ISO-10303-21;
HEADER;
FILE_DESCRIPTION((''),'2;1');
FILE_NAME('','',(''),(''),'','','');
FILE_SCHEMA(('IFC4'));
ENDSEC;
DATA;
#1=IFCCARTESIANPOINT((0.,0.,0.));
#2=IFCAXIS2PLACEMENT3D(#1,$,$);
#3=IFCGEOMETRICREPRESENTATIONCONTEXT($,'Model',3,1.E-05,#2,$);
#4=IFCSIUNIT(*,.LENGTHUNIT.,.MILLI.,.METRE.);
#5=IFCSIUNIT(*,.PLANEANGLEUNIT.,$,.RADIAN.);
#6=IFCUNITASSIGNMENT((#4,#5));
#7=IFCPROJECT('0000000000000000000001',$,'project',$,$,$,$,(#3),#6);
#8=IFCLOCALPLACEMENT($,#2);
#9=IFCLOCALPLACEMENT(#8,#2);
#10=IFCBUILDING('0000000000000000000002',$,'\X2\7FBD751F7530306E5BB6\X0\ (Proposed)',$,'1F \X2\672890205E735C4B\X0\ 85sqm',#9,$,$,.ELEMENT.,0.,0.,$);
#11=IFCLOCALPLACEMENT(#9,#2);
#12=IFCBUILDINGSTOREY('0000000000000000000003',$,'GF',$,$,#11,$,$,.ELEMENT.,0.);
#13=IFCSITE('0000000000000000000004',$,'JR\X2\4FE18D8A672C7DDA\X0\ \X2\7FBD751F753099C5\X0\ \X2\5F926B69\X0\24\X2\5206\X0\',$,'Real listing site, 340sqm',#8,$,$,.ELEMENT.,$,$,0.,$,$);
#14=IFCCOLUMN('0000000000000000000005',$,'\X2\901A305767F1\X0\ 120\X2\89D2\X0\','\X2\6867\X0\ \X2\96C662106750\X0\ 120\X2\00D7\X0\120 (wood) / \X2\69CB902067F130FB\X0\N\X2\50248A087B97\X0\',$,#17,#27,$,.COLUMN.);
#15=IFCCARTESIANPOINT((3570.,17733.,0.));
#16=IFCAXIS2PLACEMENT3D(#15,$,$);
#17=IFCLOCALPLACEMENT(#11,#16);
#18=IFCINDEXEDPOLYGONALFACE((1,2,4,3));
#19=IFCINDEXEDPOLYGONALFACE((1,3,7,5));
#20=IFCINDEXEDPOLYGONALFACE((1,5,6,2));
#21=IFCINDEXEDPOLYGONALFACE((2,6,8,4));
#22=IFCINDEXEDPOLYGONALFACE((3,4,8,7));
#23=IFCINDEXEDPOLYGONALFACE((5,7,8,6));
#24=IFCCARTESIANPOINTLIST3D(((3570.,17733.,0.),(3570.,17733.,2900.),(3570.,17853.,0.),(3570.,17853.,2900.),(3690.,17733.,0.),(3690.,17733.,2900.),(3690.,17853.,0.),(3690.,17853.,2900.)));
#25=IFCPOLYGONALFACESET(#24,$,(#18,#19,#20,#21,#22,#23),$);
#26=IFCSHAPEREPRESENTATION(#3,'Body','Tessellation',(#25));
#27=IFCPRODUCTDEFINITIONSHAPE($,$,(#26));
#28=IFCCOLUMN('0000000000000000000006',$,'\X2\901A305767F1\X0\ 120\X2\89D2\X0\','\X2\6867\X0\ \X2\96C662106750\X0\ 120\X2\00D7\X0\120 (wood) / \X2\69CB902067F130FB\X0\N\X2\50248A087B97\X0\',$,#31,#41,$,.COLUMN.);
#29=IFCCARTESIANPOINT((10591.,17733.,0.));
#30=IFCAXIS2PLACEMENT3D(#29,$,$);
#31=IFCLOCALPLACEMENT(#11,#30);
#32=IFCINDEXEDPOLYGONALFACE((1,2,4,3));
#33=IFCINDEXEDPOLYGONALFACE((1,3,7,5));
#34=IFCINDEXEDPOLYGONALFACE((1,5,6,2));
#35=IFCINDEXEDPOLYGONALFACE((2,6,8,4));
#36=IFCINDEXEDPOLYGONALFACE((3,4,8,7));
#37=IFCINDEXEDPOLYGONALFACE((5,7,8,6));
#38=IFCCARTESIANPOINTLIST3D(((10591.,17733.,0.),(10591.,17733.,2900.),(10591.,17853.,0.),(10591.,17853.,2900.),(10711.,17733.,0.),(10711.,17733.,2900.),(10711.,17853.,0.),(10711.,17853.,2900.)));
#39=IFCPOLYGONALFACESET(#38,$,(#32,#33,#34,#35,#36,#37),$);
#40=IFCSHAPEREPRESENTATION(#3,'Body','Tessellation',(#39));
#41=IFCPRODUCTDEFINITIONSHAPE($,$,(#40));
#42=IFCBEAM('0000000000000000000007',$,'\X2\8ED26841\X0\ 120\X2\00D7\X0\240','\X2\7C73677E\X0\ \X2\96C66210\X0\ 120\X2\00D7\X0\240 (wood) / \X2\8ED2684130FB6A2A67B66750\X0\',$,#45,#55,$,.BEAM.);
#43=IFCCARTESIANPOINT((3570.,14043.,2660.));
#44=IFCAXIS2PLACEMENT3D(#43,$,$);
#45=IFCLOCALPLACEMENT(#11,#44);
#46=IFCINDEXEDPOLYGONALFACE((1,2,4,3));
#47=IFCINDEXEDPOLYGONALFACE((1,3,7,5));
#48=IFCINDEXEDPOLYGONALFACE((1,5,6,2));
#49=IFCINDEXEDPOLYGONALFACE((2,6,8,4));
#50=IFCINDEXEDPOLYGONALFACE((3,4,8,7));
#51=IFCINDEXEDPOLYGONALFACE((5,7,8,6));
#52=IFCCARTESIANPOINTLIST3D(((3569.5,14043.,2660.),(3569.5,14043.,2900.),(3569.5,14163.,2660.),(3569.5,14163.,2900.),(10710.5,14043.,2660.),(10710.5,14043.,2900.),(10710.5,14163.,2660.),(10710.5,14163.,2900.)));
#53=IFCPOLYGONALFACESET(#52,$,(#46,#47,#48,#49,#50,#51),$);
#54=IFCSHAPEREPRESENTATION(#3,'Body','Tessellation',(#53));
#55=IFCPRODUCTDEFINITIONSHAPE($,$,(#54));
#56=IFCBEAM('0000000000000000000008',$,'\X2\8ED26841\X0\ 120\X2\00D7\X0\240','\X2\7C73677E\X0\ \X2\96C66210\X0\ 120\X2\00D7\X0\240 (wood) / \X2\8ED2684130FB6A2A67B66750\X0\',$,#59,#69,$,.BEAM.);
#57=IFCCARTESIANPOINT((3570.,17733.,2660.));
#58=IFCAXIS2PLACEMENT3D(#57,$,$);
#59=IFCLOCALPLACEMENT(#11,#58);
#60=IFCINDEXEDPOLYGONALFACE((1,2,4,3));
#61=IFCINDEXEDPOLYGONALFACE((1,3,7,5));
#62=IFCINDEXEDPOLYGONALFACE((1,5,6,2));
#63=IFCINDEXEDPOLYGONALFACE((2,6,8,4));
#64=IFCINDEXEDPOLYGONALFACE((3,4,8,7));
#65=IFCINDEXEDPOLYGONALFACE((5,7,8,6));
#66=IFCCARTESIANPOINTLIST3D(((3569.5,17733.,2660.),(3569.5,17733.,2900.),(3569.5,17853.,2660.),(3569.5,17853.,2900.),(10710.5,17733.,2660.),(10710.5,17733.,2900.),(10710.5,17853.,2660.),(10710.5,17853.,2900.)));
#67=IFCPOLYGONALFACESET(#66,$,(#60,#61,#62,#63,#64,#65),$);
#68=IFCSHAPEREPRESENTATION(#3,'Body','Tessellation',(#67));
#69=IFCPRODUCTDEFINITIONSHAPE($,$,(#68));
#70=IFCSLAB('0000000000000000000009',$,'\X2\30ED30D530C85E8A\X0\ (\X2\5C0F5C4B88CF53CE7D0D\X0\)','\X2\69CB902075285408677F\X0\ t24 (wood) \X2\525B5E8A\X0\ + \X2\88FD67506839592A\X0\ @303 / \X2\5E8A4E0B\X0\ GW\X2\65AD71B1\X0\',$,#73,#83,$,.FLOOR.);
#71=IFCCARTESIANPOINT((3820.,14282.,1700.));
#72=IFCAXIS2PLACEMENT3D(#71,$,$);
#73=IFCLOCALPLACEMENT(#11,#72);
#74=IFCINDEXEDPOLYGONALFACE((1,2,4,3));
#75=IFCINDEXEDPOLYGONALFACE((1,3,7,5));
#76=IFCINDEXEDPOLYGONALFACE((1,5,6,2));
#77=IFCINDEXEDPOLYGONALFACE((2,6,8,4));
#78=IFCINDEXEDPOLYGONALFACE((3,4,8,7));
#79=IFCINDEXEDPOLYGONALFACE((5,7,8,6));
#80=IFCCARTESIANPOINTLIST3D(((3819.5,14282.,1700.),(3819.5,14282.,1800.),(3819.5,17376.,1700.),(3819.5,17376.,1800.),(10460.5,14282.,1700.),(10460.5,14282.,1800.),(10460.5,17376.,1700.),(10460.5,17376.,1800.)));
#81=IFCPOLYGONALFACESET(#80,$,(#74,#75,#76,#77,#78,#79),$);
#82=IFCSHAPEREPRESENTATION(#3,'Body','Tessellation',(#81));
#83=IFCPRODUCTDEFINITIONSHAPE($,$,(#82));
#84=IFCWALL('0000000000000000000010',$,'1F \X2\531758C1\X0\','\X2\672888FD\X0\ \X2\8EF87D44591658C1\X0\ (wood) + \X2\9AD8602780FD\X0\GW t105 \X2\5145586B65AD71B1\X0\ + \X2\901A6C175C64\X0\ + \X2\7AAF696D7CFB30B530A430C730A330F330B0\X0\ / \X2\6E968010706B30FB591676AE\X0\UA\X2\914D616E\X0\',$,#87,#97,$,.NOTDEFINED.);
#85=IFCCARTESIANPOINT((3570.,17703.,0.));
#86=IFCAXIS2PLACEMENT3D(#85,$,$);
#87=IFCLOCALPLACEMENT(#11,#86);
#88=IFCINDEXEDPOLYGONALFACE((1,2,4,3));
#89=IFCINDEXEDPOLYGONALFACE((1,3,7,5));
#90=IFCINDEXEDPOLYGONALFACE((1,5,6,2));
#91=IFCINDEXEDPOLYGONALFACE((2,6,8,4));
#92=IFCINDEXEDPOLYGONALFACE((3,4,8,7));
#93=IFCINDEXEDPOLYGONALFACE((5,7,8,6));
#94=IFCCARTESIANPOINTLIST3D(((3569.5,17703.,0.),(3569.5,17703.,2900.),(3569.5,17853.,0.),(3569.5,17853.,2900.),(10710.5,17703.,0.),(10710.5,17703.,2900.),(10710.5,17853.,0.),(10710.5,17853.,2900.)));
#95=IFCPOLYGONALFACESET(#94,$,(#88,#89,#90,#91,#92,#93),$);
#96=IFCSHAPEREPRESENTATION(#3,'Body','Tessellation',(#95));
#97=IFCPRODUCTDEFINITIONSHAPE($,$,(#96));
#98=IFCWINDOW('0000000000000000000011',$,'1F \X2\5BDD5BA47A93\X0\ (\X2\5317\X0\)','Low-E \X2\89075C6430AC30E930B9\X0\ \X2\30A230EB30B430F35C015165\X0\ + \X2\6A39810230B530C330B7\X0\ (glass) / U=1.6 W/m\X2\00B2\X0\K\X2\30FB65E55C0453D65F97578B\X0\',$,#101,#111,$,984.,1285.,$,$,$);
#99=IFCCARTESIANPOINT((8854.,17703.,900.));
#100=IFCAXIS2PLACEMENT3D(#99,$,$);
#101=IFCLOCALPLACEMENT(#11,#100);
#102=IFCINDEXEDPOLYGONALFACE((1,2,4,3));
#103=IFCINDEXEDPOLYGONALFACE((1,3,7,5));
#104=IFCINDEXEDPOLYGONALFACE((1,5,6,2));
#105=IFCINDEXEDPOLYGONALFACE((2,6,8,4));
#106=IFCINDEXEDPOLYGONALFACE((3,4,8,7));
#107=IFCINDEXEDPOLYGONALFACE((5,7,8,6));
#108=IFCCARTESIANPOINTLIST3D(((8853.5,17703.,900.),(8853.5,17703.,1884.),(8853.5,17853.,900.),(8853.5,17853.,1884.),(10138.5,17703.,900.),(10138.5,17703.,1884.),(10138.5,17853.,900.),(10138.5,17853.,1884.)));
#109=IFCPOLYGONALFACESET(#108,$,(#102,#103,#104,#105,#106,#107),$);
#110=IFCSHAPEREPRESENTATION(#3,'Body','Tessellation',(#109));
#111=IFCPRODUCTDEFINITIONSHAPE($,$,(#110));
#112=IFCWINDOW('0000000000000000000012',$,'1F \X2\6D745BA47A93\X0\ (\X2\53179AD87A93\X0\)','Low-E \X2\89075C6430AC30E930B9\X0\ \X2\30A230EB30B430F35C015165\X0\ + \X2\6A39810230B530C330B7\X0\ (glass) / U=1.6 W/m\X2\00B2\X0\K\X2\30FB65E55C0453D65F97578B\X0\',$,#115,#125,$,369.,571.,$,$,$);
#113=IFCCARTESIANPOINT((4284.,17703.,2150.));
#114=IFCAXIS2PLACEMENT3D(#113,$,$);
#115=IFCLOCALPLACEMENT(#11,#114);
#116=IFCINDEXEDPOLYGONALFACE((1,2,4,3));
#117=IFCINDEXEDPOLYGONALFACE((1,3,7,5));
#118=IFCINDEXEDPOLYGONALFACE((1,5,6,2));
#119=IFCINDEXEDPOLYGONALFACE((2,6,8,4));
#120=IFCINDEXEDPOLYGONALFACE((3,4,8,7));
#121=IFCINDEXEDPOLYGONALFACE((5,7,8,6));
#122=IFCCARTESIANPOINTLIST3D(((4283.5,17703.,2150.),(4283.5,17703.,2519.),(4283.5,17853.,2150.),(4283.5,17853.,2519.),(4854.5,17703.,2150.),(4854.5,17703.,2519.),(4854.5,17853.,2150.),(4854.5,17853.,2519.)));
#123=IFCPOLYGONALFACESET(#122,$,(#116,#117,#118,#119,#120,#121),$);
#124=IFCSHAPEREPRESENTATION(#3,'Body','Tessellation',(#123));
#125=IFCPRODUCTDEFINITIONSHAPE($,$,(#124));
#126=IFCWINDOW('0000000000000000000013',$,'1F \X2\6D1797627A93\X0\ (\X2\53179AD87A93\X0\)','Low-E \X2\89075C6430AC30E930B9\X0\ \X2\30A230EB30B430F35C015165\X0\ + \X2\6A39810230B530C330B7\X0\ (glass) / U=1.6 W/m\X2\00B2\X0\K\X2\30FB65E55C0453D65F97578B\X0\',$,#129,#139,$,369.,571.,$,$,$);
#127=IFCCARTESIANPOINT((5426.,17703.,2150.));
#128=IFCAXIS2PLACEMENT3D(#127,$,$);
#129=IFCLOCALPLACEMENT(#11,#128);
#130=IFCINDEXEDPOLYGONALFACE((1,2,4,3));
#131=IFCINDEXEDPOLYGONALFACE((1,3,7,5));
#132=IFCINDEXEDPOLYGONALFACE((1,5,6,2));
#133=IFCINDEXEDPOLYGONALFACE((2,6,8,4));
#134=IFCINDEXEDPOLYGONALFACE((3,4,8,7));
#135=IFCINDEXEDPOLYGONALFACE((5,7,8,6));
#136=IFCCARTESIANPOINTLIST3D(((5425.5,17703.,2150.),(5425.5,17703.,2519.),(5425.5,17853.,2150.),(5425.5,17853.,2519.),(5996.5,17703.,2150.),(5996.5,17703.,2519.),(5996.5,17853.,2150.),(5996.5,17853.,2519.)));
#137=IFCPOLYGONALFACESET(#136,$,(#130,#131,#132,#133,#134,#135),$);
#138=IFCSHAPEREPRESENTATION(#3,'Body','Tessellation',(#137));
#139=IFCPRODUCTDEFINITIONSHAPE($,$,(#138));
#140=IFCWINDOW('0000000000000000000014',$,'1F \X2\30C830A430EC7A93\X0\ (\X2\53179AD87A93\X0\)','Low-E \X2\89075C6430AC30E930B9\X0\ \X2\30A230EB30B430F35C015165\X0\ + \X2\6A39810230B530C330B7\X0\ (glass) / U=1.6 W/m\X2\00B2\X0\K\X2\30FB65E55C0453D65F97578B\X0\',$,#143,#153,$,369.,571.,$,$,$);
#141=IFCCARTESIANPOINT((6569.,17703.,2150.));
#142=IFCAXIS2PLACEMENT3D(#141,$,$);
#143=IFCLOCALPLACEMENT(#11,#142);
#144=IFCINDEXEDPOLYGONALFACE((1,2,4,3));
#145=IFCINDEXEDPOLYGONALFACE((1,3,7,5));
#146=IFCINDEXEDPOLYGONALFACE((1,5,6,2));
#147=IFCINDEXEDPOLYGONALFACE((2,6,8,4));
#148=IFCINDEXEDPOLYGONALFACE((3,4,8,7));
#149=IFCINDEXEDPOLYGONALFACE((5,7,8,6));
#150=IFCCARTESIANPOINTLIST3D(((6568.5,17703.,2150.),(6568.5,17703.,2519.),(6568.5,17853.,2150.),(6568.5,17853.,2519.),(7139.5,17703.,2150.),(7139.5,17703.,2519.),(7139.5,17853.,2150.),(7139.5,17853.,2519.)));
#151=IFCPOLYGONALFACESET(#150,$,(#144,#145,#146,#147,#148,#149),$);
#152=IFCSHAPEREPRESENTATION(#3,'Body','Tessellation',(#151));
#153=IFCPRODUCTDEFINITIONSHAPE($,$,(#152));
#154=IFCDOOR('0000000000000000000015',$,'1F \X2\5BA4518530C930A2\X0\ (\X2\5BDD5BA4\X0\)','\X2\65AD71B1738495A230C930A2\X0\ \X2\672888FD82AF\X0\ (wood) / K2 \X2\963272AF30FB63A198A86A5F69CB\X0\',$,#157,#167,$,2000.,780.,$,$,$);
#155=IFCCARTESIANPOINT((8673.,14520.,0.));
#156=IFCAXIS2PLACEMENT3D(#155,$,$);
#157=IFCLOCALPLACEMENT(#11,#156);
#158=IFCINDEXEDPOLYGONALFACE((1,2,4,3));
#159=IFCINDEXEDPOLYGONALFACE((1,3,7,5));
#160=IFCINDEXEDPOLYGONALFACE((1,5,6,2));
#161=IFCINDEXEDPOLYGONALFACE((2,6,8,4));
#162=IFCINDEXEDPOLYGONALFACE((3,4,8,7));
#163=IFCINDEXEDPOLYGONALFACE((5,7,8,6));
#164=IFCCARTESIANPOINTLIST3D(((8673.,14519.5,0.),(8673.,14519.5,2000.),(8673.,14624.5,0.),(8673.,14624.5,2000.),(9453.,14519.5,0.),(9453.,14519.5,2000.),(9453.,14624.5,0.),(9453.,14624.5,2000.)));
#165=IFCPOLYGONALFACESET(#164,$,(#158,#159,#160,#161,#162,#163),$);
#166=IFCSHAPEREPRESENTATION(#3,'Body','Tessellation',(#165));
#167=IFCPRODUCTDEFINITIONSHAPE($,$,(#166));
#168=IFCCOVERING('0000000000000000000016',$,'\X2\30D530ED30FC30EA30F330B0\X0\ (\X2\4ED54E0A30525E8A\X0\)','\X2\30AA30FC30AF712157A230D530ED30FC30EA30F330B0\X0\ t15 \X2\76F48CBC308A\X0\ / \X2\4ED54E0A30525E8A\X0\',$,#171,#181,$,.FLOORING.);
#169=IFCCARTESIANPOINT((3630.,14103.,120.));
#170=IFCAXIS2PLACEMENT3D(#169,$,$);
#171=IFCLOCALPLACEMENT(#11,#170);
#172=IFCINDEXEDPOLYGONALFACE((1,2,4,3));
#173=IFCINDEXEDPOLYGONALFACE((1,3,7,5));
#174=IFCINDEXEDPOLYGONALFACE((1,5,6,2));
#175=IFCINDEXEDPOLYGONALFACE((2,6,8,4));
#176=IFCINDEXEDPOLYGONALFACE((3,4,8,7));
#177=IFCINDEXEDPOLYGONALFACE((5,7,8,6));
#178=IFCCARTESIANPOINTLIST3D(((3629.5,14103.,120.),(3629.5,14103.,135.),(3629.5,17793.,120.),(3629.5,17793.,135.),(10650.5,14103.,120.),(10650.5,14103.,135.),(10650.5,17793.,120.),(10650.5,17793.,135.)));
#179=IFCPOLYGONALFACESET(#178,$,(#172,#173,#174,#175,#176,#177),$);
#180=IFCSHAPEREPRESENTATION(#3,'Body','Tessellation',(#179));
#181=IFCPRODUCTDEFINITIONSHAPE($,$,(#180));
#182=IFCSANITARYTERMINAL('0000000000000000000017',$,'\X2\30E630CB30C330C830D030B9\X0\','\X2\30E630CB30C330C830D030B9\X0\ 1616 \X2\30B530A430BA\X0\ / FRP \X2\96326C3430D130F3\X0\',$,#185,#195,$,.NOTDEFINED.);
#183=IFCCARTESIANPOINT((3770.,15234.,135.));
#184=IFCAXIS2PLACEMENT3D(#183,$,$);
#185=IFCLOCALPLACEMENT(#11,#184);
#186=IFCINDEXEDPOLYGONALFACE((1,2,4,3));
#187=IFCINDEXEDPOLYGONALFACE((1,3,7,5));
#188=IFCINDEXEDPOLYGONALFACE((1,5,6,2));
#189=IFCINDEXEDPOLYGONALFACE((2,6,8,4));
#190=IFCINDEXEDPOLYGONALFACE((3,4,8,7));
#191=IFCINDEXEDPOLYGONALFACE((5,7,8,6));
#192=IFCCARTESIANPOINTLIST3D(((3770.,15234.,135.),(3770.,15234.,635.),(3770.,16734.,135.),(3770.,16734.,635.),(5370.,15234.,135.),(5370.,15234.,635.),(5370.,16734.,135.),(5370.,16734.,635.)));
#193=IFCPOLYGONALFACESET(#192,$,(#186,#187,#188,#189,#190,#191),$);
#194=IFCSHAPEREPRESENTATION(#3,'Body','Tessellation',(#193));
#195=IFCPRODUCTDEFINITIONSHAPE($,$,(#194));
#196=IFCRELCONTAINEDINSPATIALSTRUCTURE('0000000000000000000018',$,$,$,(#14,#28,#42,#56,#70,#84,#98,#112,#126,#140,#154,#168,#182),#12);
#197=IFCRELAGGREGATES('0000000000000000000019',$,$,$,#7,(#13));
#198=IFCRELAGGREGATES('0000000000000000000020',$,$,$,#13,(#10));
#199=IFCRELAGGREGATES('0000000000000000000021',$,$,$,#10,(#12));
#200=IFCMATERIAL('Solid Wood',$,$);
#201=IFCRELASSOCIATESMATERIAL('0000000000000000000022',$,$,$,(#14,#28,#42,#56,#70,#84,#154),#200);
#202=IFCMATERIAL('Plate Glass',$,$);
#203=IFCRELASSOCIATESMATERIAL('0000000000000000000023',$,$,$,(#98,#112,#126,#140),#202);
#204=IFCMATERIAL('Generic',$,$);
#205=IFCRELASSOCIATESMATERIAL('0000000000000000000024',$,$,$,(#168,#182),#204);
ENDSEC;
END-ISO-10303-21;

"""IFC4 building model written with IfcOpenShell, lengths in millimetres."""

from ifc_helpers import new_model, si_unit, frame, frame_2d, origin, place, context, project, spatial, rectangle, extrude, material, element, fill, save


model = new_model("IFC4")

# Units and contexts
model_context = context("Model", 3, precision=1e-05, world=origin())
ifc_project = project(units=[si_unit("LENGTHUNIT", "METRE", prefix="MILLI"), si_unit("PLANEANGLEUNIT", "RADIAN")], contexts=[model_context])

# Site, building, storey
site_placement = place(None, origin())
site = spatial("IfcSite", under=ifc_project, at=site_placement, Name="JR信越本線 羽生田駅 徒歩24分", ObjectType="Real listing site, 340sqm", CompositionType="ELEMENT", RefElevation=0.0)
building_placement = place(site_placement, origin())
building = spatial("IfcBuilding", under=site, at=building_placement, Name="羽生田の家 (Proposed)", ObjectType="1F 木造平屋 85sqm", CompositionType="ELEMENT", ElevationOfRefHeight=0.0, ElevationOfTerrain=0.0)
storey_placement = place(building_placement, origin())
storey = spatial("IfcBuildingStorey", under=building, at=storey_placement, Name="GF", CompositionType="ELEMENT", Elevation=0.0)

# Columns
ifc_material_1 = material(Name="Solid Wood")
column_1_placement = place(storey_placement, frame((3570.0, 17733.0, 0.0)))
element("IfcColumn", 1, at=column_1_placement, inside=storey, material=ifc_material_1, Name="通し柱 120角", Description="桧 集成材 120×120 (wood) / 構造柱・N値計算", PredefinedType="COLUMN", context=model_context, shape_type="SweptSolid", body=[
    extrude(rectangle(XDim=120.0, YDim=120.0, at=frame_2d((60.0, 60.0))), frame((3570.0, 17733.0, 0.0)), (0.0, 0.0, 1.0), 2900.0),
])
column_2_placement = place(storey_placement, frame((10591.0, 17733.0, 0.0)))
element("IfcColumn", 2, at=column_2_placement, inside=storey, material=ifc_material_1, Name="通し柱 120角", Description="桧 集成材 120×120 (wood) / 構造柱・N値計算", PredefinedType="COLUMN", context=model_context, shape_type="SweptSolid", body=[
    extrude(rectangle(XDim=120.0, YDim=120.0, at=frame_2d((60.0, 60.0))), frame((10591.0, 17733.0, 0.0)), (0.0, 0.0, 1.0), 2900.0),
])

# Beams
beam_1_placement = place(storey_placement, frame((3570.0, 14043.0, 2660.0)))
element("IfcBeam", 3, at=beam_1_placement, inside=storey, material=ifc_material_1, Name="軒桁 120×240", Description="米松 集成 120×240 (wood) / 軒桁・横架材", PredefinedType="BEAM", context=model_context, shape_type="SweptSolid", body=[
    extrude(rectangle(XDim=7141.0, YDim=120.0, at=frame_2d((3570.0, 60.0))), frame((3570.0, 14043.0, 2660.0)), (0.0, 0.0, 1.0), 240.0),
])
beam_2_placement = place(storey_placement, frame((3570.0, 17733.0, 2660.0)))
element("IfcBeam", 4, at=beam_2_placement, inside=storey, material=ifc_material_1, Name="軒桁 120×240", Description="米松 集成 120×240 (wood) / 軒桁・横架材", PredefinedType="BEAM", context=model_context, shape_type="SweptSolid", body=[
    extrude(rectangle(XDim=7141.0, YDim=120.0, at=frame_2d((3570.0, 60.0))), frame((3570.0, 17733.0, 2660.0)), (0.0, 0.0, 1.0), 240.0),
])

# Slab
slab_placement = place(storey_placement, frame((3820.0, 14282.0, 1700.0)))
element("IfcSlab", 5, at=slab_placement, inside=storey, material=ifc_material_1, Name="ロフト床 (小屋裏収納)", Description="構造用合板 t24 (wood) 剛床 + 製材根太 @303 / 床下 GW断熱", PredefinedType="FLOOR", context=model_context, shape_type="SweptSolid", body=[
    extrude(rectangle(XDim=6641.0, YDim=3094.0, at=frame_2d((3320.0, 1547.0))), frame((3820.0, 14282.0, 1700.0)), (0.0, 0.0, 1.0), 100.0),
])

# Wall, openings, windows
wall_1_placement = place(storey_placement, frame((3570.0, 17703.0, 0.0)))
wall_1 = element("IfcWall", 6, at=wall_1_placement, inside=storey, material=ifc_material_1, Name="1F 北壁", Description="木製 軸組外壁 (wood) + 高性能GW t105 充填断熱 + 通気層 + 窯業系サイディング / 準耐火・外皮UA配慮", PredefinedType="NOTDEFINED", context=model_context, shape_type="SweptSolid", body=[
    extrude(rectangle(XDim=7141.0, YDim=150.0, at=frame_2d((3570.0, 75.0))), frame((3570.0, 17703.0, 0.0)), (0.0, 0.0, 1.0), 2900.0),
])
opening_1_placement = place(storey_placement, frame((8854.0, 17703.0, 900.0)))
opening_1 = element("IfcOpeningElement", 7, at=opening_1_placement, cuts=wall_1, PredefinedType="NOTDEFINED", context=model_context, shape_type="SweptSolid", body=[
    extrude(rectangle(XDim=1285.0, YDim=150.0, at=frame_2d((642.0, 75.0))), frame((8854.0, 17703.0, 900.0)), (0.0, 0.0, 1.0), 984.0),
])
opening_2_placement = place(storey_placement, frame((4284.0, 17703.0, 2150.0)))
opening_2 = element("IfcOpeningElement", 8, at=opening_2_placement, cuts=wall_1, PredefinedType="NOTDEFINED", context=model_context, shape_type="SweptSolid", body=[
    extrude(rectangle(XDim=571.0, YDim=150.0, at=frame_2d((285.0, 75.0))), frame((4284.0, 17703.0, 2150.0)), (0.0, 0.0, 1.0), 369.0),
])
opening_3_placement = place(storey_placement, frame((5426.0, 17703.0, 2150.0)))
opening_3 = element("IfcOpeningElement", 9, at=opening_3_placement, cuts=wall_1, PredefinedType="NOTDEFINED", context=model_context, shape_type="SweptSolid", body=[
    extrude(rectangle(XDim=571.0, YDim=150.0, at=frame_2d((285.0, 75.0))), frame((5426.0, 17703.0, 2150.0)), (0.0, 0.0, 1.0), 369.0),
])
opening_4_placement = place(storey_placement, frame((6569.0, 17703.0, 2150.0)))
opening_4 = element("IfcOpeningElement", 10, at=opening_4_placement, cuts=wall_1, PredefinedType="NOTDEFINED", context=model_context, shape_type="SweptSolid", body=[
    extrude(rectangle(XDim=571.0, YDim=150.0, at=frame_2d((285.0, 75.0))), frame((6569.0, 17703.0, 2150.0)), (0.0, 0.0, 1.0), 369.0),
])
ifc_material_2 = material(Name="Plate Glass")
window_1_placement = place(storey_placement, frame((8854.0, 17703.0, 900.0)))
window_1 = element("IfcWindow", 11, at=window_1_placement, inside=storey, material=ifc_material_2, Name="1F 寝室窓 (北)", Description="Low-E 複層ガラス アルゴン封入 + 樹脂サッシ (glass) / U=1.6 W/m²K・日射取得型", OverallHeight=984.0, OverallWidth=1285.0, context=model_context, shape_type="SweptSolid", body=[
    extrude(rectangle(XDim=1285.0, YDim=150.0, at=frame_2d((642.0, 75.0))), frame((8854.0, 17703.0, 900.0)), (0.0, 0.0, 1.0), 984.0),
])
fill(opening_1, window_1)
window_2_placement = place(storey_placement, frame((4284.0, 17703.0, 2150.0)))
window_2 = element("IfcWindow", 12, at=window_2_placement, inside=storey, material=ifc_material_2, Name="1F 浴室窓 (北高窓)", Description="Low-E 複層ガラス アルゴン封入 + 樹脂サッシ (glass) / U=1.6 W/m²K・日射取得型", OverallHeight=369.0, OverallWidth=571.0, context=model_context, shape_type="SweptSolid", body=[
    extrude(rectangle(XDim=571.0, YDim=150.0, at=frame_2d((285.0, 75.0))), frame((4284.0, 17703.0, 2150.0)), (0.0, 0.0, 1.0), 369.0),
])
fill(opening_2, window_2)
window_3_placement = place(storey_placement, frame((5426.0, 17703.0, 2150.0)))
window_3 = element("IfcWindow", 13, at=window_3_placement, inside=storey, material=ifc_material_2, Name="1F 洗面窓 (北高窓)", Description="Low-E 複層ガラス アルゴン封入 + 樹脂サッシ (glass) / U=1.6 W/m²K・日射取得型", OverallHeight=369.0, OverallWidth=571.0, context=model_context, shape_type="SweptSolid", body=[
    extrude(rectangle(XDim=571.0, YDim=150.0, at=frame_2d((285.0, 75.0))), frame((5426.0, 17703.0, 2150.0)), (0.0, 0.0, 1.0), 369.0),
])
fill(opening_3, window_3)
window_4_placement = place(storey_placement, frame((6569.0, 17703.0, 2150.0)))
window_4 = element("IfcWindow", 14, at=window_4_placement, inside=storey, material=ifc_material_2, Name="1F トイレ窓 (北高窓)", Description="Low-E 複層ガラス アルゴン封入 + 樹脂サッシ (glass) / U=1.6 W/m²K・日射取得型", OverallHeight=369.0, OverallWidth=571.0, context=model_context, shape_type="SweptSolid", body=[
    extrude(rectangle(XDim=571.0, YDim=150.0, at=frame_2d((285.0, 75.0))), frame((6569.0, 17703.0, 2150.0)), (0.0, 0.0, 1.0), 369.0),
])
fill(opening_4, window_4)

# Door
door_1_placement = place(storey_placement, frame((8673.0, 14520.0, 0.0)))
element("IfcDoor", 15, at=door_1_placement, inside=storey, material=ifc_material_1, Name="1F 室内ドア (寝室)", Description="断熱玄関ドア 木製芯 (wood) / K2 防犯・採風機構", OverallHeight=2000.0, OverallWidth=780.0, context=model_context, shape_type="SweptSolid", body=[
    extrude(rectangle(XDim=780.0, YDim=105.0, at=frame_2d((390.0, 52.0))), frame((8673.0, 14520.0, 0.0)), (0.0, 0.0, 1.0), 2000.0),
])

# Covering
ifc_material_3 = material(Name="Generic")
covering_placement = place(storey_placement, frame((3630.0, 14103.0, 120.0)))
element("IfcCovering", 16, at=covering_placement, inside=storey, material=ifc_material_3, Name="フローリング (仕上げ床)", Description="オーク無垢フローリング t15 直貼り / 仕上げ床", PredefinedType="FLOORING", context=model_context, shape_type="SweptSolid", body=[
    extrude(rectangle(XDim=7021.0, YDim=3690.0, at=frame_2d((3510.0, 1845.0))), frame((3630.0, 14103.0, 120.0)), (0.0, 0.0, 1.0), 15.0),
])

# Sanitary terminal
sanitary_terminal_1_placement = place(storey_placement, frame((3770.0, 15234.0, 135.0)))
element("IfcSanitaryTerminal", 17, at=sanitary_terminal_1_placement, inside=storey, material=ifc_material_3, Name="ユニットバス", Description="ユニットバス 1616 サイズ / FRP 防水パン", PredefinedType="NOTDEFINED", context=model_context, shape_type="SweptSolid", body=[
    extrude(rectangle(XDim=1600.0, YDim=1500.0, at=frame_2d((800.0, 750.0))), frame((3770.0, 15234.0, 135.0)), (0.0, 0.0, 1.0), 500.0),
])

save(model, "model.ifc")
